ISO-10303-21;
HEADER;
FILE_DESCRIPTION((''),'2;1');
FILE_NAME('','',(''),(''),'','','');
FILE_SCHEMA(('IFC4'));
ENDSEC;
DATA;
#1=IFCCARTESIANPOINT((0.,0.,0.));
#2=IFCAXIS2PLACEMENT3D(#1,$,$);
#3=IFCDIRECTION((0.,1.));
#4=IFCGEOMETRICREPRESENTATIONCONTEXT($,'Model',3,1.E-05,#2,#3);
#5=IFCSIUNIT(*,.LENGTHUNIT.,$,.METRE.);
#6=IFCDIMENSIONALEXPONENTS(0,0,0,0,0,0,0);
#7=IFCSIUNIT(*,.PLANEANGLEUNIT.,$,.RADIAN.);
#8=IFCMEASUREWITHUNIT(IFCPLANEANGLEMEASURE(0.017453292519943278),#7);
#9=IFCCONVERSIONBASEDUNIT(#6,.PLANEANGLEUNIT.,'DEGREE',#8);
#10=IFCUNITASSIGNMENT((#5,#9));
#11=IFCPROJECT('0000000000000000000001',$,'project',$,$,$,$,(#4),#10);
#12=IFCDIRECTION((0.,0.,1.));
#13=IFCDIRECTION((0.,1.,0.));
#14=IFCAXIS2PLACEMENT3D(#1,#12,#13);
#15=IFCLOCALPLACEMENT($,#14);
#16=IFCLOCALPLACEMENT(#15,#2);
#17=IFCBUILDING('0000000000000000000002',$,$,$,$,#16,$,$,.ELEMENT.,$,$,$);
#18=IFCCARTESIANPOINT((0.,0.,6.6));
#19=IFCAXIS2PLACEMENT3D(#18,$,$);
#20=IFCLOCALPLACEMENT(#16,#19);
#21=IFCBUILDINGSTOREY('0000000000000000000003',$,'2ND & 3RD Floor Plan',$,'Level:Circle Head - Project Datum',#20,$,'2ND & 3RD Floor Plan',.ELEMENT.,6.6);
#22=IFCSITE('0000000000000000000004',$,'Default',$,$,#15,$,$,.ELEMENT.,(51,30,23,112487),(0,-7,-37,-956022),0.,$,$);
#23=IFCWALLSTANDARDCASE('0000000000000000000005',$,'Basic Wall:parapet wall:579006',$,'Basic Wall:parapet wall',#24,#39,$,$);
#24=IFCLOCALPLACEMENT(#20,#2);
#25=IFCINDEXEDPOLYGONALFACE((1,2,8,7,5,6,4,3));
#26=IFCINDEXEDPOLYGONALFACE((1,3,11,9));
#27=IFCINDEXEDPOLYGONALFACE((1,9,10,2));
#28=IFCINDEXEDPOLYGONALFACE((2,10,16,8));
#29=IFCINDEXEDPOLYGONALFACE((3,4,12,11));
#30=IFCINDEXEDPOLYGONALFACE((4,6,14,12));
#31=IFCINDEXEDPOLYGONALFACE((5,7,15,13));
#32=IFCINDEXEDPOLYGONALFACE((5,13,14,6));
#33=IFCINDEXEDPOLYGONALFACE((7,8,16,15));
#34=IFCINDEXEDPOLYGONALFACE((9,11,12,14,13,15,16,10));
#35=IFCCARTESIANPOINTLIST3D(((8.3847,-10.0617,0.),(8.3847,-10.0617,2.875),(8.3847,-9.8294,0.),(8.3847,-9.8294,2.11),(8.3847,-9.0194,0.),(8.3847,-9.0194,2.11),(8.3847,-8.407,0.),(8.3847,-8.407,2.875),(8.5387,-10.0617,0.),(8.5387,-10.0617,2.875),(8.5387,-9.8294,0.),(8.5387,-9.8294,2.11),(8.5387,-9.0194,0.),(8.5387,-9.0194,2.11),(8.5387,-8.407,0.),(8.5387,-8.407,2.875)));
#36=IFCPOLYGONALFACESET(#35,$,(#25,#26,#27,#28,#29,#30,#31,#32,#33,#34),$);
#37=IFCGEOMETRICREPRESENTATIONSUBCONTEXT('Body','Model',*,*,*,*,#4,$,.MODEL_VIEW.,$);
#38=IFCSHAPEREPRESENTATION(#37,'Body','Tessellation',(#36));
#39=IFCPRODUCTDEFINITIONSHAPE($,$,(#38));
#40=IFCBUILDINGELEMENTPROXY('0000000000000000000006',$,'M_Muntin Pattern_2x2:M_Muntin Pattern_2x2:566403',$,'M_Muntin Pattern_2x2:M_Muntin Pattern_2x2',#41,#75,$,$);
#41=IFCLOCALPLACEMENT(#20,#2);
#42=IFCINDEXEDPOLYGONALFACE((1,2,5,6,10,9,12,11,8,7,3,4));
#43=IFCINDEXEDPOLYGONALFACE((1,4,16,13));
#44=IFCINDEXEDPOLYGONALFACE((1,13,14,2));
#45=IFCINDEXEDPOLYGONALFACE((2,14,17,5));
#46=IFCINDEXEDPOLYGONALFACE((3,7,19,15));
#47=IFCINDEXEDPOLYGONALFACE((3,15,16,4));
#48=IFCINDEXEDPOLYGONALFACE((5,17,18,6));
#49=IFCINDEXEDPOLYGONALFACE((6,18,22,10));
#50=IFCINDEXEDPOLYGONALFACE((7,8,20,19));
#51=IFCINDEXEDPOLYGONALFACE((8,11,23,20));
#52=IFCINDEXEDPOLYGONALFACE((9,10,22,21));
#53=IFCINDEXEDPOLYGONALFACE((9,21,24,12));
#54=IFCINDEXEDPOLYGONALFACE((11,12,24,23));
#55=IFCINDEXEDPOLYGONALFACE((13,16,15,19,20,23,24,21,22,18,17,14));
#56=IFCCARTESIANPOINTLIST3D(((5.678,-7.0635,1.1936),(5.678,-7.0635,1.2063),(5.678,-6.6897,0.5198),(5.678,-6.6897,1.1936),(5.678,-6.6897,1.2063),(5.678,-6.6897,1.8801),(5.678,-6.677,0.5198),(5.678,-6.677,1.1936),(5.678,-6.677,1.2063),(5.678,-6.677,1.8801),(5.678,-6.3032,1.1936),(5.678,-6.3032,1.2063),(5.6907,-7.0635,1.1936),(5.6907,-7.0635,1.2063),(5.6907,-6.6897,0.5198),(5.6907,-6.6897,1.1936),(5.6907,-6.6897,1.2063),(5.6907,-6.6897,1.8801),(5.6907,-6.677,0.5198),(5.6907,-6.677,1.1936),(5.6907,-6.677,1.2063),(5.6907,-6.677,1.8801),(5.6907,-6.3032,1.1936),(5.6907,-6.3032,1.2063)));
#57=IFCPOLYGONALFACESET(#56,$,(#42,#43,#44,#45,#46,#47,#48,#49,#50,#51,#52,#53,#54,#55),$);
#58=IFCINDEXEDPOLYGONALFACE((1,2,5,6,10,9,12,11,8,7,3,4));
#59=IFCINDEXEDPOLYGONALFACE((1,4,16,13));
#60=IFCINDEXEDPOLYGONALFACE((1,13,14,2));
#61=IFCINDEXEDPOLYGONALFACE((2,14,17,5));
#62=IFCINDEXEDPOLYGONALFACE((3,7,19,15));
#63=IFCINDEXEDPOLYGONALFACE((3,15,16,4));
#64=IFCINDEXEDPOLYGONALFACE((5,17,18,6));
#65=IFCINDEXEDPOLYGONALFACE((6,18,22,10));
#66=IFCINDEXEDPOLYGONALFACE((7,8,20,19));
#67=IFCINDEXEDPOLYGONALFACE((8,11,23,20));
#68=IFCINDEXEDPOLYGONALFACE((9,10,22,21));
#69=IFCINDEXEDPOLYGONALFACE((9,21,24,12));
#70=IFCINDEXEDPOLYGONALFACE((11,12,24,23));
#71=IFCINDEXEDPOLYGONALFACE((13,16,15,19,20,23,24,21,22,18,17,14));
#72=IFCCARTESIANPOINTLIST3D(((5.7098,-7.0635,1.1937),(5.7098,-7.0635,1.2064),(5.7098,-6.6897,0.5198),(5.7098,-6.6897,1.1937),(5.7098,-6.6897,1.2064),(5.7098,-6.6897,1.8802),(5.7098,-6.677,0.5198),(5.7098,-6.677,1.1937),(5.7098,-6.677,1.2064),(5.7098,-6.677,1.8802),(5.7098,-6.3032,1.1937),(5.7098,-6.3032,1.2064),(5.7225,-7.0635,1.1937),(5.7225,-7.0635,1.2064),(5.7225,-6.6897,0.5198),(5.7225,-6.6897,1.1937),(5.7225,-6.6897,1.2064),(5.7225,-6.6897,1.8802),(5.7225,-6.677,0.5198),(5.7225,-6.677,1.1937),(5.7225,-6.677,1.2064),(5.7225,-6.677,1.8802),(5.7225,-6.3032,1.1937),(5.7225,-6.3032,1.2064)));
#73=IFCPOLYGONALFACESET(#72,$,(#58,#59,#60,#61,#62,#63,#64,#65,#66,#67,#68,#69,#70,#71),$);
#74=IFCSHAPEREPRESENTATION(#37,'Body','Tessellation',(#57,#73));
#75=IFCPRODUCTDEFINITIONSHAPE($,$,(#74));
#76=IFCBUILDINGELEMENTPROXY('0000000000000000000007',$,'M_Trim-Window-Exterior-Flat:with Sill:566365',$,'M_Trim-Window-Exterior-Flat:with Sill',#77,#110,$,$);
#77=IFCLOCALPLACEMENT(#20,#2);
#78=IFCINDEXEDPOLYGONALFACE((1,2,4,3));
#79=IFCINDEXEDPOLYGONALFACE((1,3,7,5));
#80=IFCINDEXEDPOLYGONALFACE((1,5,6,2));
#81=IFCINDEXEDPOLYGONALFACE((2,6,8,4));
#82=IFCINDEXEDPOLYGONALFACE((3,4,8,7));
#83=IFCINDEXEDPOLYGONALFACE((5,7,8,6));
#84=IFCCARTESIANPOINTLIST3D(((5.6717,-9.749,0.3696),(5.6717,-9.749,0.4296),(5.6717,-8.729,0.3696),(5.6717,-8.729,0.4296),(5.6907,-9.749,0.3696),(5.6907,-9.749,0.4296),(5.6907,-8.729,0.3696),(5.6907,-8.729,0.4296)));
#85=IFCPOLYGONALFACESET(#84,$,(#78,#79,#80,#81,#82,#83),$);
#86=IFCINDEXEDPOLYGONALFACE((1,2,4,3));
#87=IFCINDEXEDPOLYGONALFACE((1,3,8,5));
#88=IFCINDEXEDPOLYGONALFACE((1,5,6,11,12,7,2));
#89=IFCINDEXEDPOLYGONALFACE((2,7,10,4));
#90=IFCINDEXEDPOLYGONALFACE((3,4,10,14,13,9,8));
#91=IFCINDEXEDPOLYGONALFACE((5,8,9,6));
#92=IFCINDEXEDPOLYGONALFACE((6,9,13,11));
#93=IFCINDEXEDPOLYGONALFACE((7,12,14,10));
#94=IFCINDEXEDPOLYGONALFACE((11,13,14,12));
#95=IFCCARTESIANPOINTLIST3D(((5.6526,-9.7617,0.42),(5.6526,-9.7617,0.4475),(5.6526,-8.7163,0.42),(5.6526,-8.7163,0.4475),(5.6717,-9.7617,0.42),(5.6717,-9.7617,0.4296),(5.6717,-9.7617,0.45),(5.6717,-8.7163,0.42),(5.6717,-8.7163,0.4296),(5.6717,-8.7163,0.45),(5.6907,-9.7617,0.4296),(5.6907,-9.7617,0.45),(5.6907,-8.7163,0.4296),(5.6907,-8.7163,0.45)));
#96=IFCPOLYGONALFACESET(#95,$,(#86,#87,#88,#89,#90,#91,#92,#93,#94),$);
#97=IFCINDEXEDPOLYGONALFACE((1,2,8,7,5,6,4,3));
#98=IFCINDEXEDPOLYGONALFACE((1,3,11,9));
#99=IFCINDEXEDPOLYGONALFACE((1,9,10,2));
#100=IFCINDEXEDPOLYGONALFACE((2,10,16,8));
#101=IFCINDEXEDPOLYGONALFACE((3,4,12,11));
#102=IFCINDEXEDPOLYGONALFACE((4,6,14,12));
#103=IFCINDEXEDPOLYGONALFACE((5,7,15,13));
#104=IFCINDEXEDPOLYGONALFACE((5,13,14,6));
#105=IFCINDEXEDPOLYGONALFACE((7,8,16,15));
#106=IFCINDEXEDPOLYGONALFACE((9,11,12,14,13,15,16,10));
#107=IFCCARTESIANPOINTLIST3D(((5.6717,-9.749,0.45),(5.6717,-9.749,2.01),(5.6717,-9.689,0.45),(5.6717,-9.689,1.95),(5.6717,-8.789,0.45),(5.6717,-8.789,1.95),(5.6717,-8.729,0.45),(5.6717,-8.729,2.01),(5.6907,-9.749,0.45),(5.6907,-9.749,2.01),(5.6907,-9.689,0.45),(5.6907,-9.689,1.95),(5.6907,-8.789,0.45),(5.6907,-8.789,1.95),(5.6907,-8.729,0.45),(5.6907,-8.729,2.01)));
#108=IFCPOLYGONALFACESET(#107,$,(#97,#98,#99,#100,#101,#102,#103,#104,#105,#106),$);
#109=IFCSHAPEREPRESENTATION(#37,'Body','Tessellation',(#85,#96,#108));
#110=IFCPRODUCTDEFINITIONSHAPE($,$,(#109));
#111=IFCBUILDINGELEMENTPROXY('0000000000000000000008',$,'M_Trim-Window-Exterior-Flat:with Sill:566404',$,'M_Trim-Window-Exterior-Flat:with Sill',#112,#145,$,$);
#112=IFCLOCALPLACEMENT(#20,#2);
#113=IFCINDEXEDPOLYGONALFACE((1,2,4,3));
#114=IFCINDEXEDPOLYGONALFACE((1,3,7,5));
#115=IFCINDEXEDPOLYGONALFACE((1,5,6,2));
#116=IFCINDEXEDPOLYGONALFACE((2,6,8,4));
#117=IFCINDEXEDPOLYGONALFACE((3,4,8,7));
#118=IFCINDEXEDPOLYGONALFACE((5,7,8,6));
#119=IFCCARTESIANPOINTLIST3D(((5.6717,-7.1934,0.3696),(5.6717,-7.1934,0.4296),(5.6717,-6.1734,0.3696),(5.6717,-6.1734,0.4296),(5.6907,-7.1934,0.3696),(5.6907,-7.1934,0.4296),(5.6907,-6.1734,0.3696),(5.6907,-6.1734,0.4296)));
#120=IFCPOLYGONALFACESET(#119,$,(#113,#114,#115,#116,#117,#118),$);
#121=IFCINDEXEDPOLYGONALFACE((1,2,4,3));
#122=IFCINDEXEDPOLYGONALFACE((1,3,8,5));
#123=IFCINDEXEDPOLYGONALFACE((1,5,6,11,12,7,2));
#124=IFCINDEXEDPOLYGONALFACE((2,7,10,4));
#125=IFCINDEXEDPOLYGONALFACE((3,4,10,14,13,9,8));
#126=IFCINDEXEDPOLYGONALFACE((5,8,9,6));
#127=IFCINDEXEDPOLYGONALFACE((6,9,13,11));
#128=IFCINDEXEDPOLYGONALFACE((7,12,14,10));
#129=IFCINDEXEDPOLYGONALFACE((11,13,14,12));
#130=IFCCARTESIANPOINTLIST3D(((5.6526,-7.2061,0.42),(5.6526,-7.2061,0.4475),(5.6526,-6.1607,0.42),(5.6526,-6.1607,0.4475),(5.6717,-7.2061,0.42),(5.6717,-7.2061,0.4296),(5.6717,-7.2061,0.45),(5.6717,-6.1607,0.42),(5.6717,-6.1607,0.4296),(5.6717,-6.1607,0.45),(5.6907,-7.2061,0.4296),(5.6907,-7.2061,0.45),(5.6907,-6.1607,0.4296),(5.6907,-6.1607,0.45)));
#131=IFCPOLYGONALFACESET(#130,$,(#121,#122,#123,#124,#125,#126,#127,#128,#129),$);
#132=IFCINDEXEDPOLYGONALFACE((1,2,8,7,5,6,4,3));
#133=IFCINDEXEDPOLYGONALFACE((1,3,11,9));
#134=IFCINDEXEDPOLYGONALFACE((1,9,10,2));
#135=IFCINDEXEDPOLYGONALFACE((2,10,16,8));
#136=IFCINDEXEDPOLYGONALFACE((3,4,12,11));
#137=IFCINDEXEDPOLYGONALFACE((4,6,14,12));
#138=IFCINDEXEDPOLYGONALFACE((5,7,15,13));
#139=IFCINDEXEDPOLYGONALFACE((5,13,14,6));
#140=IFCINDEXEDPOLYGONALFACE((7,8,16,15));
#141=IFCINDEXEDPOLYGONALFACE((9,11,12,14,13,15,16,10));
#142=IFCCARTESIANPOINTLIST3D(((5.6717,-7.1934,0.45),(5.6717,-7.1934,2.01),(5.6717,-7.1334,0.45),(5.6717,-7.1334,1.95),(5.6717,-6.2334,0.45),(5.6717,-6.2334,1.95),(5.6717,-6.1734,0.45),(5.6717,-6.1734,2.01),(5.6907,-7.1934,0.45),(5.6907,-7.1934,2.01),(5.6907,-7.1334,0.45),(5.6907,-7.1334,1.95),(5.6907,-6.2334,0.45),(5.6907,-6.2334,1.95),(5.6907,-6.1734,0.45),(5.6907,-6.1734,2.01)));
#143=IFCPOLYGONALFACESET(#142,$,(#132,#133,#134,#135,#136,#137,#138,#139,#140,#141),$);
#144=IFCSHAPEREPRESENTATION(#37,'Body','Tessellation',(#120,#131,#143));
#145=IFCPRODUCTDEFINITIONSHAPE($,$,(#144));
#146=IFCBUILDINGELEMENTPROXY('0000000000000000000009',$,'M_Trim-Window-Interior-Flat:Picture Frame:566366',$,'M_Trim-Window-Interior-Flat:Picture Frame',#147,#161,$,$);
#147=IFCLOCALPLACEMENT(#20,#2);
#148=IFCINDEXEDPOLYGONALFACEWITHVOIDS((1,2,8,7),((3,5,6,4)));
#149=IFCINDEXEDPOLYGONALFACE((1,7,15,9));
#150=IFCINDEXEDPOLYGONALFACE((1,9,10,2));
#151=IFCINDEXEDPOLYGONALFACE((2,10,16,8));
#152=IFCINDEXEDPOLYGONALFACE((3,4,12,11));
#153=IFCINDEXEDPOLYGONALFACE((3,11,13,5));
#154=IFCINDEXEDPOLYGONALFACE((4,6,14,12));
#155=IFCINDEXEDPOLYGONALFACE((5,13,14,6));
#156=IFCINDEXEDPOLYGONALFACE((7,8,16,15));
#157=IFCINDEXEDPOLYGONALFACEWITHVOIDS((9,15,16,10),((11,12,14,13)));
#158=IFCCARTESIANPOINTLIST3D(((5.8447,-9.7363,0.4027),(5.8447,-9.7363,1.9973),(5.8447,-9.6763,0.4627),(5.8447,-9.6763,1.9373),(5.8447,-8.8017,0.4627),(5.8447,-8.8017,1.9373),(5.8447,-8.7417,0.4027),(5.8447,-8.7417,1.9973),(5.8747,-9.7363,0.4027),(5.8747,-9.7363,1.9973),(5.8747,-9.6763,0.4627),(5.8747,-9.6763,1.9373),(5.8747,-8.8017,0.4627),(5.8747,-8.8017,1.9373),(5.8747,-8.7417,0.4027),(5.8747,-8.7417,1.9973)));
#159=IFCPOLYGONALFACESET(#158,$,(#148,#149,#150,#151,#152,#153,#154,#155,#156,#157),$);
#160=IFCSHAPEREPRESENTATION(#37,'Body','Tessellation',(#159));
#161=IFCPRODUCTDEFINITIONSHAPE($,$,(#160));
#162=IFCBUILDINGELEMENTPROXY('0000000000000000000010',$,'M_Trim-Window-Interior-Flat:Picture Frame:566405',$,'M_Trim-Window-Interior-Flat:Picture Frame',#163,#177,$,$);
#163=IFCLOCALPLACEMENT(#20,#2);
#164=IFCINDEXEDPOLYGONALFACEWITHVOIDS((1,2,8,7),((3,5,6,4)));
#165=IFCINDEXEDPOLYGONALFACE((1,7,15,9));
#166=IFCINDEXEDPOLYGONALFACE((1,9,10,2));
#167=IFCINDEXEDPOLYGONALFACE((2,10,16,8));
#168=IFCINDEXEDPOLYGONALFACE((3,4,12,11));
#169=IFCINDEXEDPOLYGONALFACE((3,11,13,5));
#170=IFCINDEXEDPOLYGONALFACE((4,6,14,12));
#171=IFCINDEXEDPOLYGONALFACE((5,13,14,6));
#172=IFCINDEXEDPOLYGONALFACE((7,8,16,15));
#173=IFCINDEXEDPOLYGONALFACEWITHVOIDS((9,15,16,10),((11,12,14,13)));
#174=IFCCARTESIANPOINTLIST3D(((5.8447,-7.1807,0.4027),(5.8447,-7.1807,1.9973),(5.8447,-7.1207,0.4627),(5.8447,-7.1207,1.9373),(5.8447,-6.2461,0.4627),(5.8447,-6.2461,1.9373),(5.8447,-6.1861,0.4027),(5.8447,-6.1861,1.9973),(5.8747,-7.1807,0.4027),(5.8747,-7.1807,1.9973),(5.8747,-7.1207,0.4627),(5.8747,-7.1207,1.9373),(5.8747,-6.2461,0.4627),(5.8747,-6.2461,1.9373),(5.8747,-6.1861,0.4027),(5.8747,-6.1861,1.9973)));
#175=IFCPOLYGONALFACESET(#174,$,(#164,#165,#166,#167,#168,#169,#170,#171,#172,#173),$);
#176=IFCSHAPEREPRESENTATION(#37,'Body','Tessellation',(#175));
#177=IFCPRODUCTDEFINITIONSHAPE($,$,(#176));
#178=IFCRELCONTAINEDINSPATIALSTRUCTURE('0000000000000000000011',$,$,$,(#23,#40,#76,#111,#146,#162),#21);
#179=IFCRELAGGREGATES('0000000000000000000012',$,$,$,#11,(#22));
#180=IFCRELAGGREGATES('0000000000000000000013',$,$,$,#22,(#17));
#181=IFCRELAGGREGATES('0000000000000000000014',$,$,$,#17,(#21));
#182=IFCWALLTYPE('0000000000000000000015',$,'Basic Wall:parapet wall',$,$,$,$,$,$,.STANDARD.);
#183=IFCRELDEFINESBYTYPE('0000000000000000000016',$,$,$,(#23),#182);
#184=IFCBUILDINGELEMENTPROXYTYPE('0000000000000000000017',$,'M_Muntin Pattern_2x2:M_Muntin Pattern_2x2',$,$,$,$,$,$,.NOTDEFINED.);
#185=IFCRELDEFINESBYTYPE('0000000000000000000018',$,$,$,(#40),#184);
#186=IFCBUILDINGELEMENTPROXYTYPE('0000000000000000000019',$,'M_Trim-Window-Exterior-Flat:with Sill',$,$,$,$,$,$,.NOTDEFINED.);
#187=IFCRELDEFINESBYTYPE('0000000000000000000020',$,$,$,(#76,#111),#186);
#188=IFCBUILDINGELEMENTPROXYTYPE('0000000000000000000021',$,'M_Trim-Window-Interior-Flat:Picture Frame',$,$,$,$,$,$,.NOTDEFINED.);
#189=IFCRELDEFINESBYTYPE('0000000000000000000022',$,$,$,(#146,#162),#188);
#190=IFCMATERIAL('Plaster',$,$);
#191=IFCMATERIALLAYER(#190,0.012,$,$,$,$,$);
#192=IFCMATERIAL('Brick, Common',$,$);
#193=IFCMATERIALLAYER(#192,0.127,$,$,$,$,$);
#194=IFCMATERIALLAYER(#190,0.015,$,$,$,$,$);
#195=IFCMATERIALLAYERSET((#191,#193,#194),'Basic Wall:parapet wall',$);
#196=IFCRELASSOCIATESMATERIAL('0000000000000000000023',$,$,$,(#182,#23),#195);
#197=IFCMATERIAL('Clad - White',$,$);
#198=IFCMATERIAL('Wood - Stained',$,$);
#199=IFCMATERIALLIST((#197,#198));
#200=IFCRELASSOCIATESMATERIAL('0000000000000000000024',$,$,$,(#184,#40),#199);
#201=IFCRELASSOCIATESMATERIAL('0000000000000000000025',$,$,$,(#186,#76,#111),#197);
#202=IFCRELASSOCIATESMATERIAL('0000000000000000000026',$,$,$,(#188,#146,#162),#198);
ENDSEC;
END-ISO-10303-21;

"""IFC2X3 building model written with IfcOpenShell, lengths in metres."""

from ifc_helpers import new_model, entity, si_unit, converted_unit, direction, frame, frame_2d, origin, place, context, subcontext, project, spatial, polyline, rectangle, outline, extrude, clip, bounded_halfspace, source, transform, mapped, material, material_list, layer, layer_set, layer_usage, type_object, type_shapes, element, save


model = new_model("IFC2X3")

# Units and contexts
model_context = context("Model", 3, precision=1e-05, world=origin(), true_north=direction((0.0, 1.0)))
body_context = subcontext(model_context, "Body", "Model", "MODEL_VIEW")
ifc_project = project(units=[si_unit("LENGTHUNIT", "METRE"), converted_unit("PLANEANGLEUNIT", "DEGREE", entity("IfcPlaneAngleMeasure", 0.017453292519943278), si_unit("PLANEANGLEUNIT", "RADIAN"), dimensions=[0, 0, 0, 0, 0, 0, 0])], contexts=[model_context])

# Site, building, storey
site_placement = place(None, frame((0.0, 0.0, 0.0), z_axis=(0.0, 0.0, 1.0), x_axis=(0.0, 1.0, 0.0)))
site = spatial("IfcSite", under=ifc_project, at=site_placement, Name="Default", CompositionType="ELEMENT", RefLatitude=(51, 30, 23, 112487), RefLongitude=(0, -7, -37, -956022), RefElevation=0.0)
building_placement = place(site_placement, origin())
building = spatial("IfcBuilding", under=site, at=building_placement, CompositionType="ELEMENT")
storey_placement = place(building_placement, frame((0.0, 0.0, 6.6)))
storey = spatial("IfcBuildingStorey", under=building, at=storey_placement, Name="2ND & 3RD Floor Plan", ObjectType="Level:Circle Head - Project Datum", LongName="2ND & 3RD Floor Plan", CompositionType="ELEMENT", Elevation=6.6)

# Shared definitions
ifc_material_1 = material(Name="Plaster")
ifc_material_2 = material(Name="Brick, Common")

# Shared definitions
ifc_layer_1 = layer(ifc_material_1, 0.012)
ifc_layer_2 = layer(ifc_material_2, 0.127)
ifc_layer_3 = layer(ifc_material_1, 0.015)
ifc_layer_set_1 = layer_set([ifc_layer_1, ifc_layer_2, ifc_layer_3], Name="Basic Wall:parapet wall")
wall_type_1 = type_object("IfcWallType", Name="Basic Wall:parapet wall", PredefinedType="STANDARD", material=ifc_layer_set_1)

# Wall, opening
ifc_layer_usage_1 = layer_usage(ifc_layer_set_1, "AXIS2", "NEGATIVE", 0.077)
wall_1_placement = place(storey_placement, frame((8.4617, -8.407, 0.0), z_axis=(0.0, 0.0, 1.0), x_axis=(0.0, -1.0, 0.0)))
wall_1 = element("IfcWallStandardCase", 1, at=wall_1_placement, inside=storey, type_object=wall_type_1, material=ifc_layer_usage_1, Name="Basic Wall:parapet wall:579006", ObjectType="Basic Wall:parapet wall", context=body_context, shape_type="Clipping", body=[
    clip(extrude(rectangle(XDim=1.6547, YDim=0.154, at=frame_2d((0.8273, 0.0), x_axis=(-1.0, 0.0))), origin(), (0.0, 0.0, 1.0), 2.875), bounded_halfspace(frame((0.0, -0.077, 2.875), z_axis=(0.0, 0.0, -1.0), x_axis=(1.0, 0.0, 0.0)), True, frame((0.0, -0.077, 2.875)), polyline([(0.0, 0.0), (1.6547, 0.0), (1.6547, 0.154), (0.0, 0.154), (0.0, 0.0)]))),
])
opening_1_placement = place(wall_1_placement, frame((0.6123, -0.077, 0.0)))
element("IfcOpeningElement", 2, at=opening_1_placement, cuts=wall_1, ObjectType="Opening", context=body_context, shape_type="SweptSolid", body=[
    extrude(rectangle(XDim=2.11, YDim=0.81, at=frame_2d((1.055, 0.405), x_axis=(1.0, 0.0))), frame((0.0, 0.0, 0.0), z_axis=(0.0, 1.0, 0.0), x_axis=(0.0, 0.0, 1.0)), (0.0, 0.0, 1.0), 0.154),
])

# Building element proxies
ifc_material_3 = material(Name="Clad - White")
ifc_material_4 = material(Name="Wood - Stained")
ifc_material_list = material_list([ifc_material_3, ifc_material_4])
building_element_proxy_type_1 = type_object("IfcBuildingElementProxyType", Name="M_Muntin Pattern_2x2:M_Muntin Pattern_2x2", PredefinedType="NOTDEFINED", material=ifc_material_list)
shared_shape_1 = source(origin(), body_context, "Body", "SweptSolid", [
    extrude(outline(polyline([(0.0064, -0.0064), (0.6801, -0.0064), (0.6801, 0.0063), (0.0064, 0.0063), (0.0064, 0.3802), (-0.0063, 0.3802), (-0.0063, 0.0063), (-0.6802, 0.0063), (-0.6802, -0.0064), (-0.0063, -0.0064), (-0.0063, -0.3801), (0.0064, -0.3801), (0.0064, -0.0064)])), frame((0.0, 0.0095, 0.6801), z_axis=(0.0, 1.0, 0.0), x_axis=(0.0, 0.0, 1.0)), (0.0, 0.0, 1.0), 0.0127),
    extrude(outline(polyline([(0.0064, -0.0064), (0.6802, -0.0064), (0.6802, 0.0063), (0.0064, 0.0063), (0.0064, 0.3802), (-0.0063, 0.3802), (-0.0063, 0.0063), (-0.6802, 0.0063), (-0.6802, -0.0064), (-0.0063, -0.0064), (-0.0063, -0.3801), (0.0064, -0.3801), (0.0064, -0.0064)])), frame((0.0, -0.0222, 0.6802), z_axis=(0.0, 1.0, 0.0), x_axis=(0.0, 0.0, 1.0)), (0.0, 0.0, 1.0), 0.0127),
])
type_shapes(building_element_proxy_type_1, [shared_shape_1])
proxy_placement = place(storey_placement, frame((5.7002, -6.6834, 0.5198), z_axis=(0.0, 0.0, 1.0), x_axis=(0.0, 1.0, 0.0)))
element("IfcBuildingElementProxy", 3, at=proxy_placement, inside=storey, type_object=building_element_proxy_type_1, material=ifc_material_list, Name="M_Muntin Pattern_2x2:M_Muntin Pattern_2x2:566403", ObjectType="M_Muntin Pattern_2x2:M_Muntin Pattern_2x2", context=body_context, shape_type="MappedRepresentation", body=[
    mapped(shared_shape_1, transform((0.0, 0.0, 0.0), scale=1.0)),
])
building_element_proxy_type_2 = type_object("IfcBuildingElementProxyType", Name="M_Trim-Window-Exterior-Flat:with Sill", PredefinedType="NOTDEFINED", material=ifc_material_3)
shared_shape_2 = source(origin(), body_context, "Body", "SweptSolid", [
    extrude(rectangle(XDim=1.02, YDim=0.06, at=frame_2d((0.0, 0.0), x_axis=(1.0, 0.0))), frame((0.0, -1.5504, 0.0), z_axis=(0.0, 0.0, 1.0), x_axis=(-1.0, 0.0, 0.0)), (0.0, 0.0, 1.0), 0.019),
    extrude(outline(polyline([(-0.019, -0.0152), (0.0, -0.0152), (0.0, -0.0057), (0.019, -0.0057), (0.019, 0.0148), (0.0, 0.0148), (-0.019, 0.0123), (-0.019, -0.0152)])), frame((-0.5227, -1.5148, 0.019), z_axis=(1.0, 0.0, 0.0), x_axis=(0.0, 0.0, -1.0)), (0.0, 0.0, 1.0), 1.0454),
    extrude(outline(polyline([(-0.795, -0.51), (0.765, -0.51), (0.765, -0.45), (-0.735, -0.45), (-0.735, 0.45), (0.765, 0.45), (0.765, 0.51), (-0.795, 0.51), (-0.795, -0.51)])), frame((0.0, -0.735, 0.0), z_axis=(0.0, 0.0, 1.0), x_axis=(0.0, -1.0, 0.0)), (0.0, 0.0, 1.0), 0.019),
])
type_shapes(building_element_proxy_type_2, [shared_shape_2])
for number, where, z_axis, x_axis, name in (
    (4, (5.6907, -9.239, 1.95), (-1.0, 0.0, 0.0), (0.0, -1.0, 0.0), "M_Trim-Window-Exterior-Flat:with Sill:566365"),
    (5, (5.6907, -6.6834, 1.95), (-1.0, 0.0, 0.0), (0.0, -1.0, 0.0), "M_Trim-Window-Exterior-Flat:with Sill:566404"),
):
    element("IfcBuildingElementProxy", number, at=place(storey_placement, frame(where, z_axis=z_axis, x_axis=x_axis)), inside=storey, type_object=building_element_proxy_type_2, material=ifc_material_3, Name=name, ObjectType="M_Trim-Window-Exterior-Flat:with Sill", context=body_context, shape_type="MappedRepresentation", body=[
        mapped(shared_shape_2, transform((0.0, 0.0, 0.0), scale=1.0)),
    ])
building_element_proxy_type_3 = type_object("IfcBuildingElementProxyType", Name="M_Trim-Window-Interior-Flat:Picture Frame", PredefinedType="NOTDEFINED", material=ifc_material_4)
shared_shape_3 = source(origin(), body_context, "Body", "SweptSolid", [
    extrude(outline(polyline([(-0.4973, -0.7973), (0.4973, -0.7973), (0.4973, 0.7973), (-0.4973, 0.7973), (-0.4973, -0.7973)]), holes=[polyline([(-0.4373, -0.7373), (-0.4373, 0.7373), (0.4373, 0.7373), (0.4373, -0.7373), (-0.4373, -0.7373)])]), frame((0.0, -0.75, 0.0), z_axis=(0.0, 0.0, 1.0), x_axis=(-1.0, 0.0, 0.0)), (0.0, 0.0, 1.0), 0.03),
])
type_shapes(building_element_proxy_type_3, [shared_shape_3])
for number, where, z_axis, x_axis, name in (
    (6, (5.8447, -9.239, 1.95), (1.0, 0.0, 0.0), (0.0, 1.0, 0.0), "M_Trim-Window-Interior-Flat:Picture Frame:566366"),
    (7, (5.8447, -6.6834, 1.95), (1.0, 0.0, 0.0), (0.0, 1.0, 0.0), "M_Trim-Window-Interior-Flat:Picture Frame:566405"),
):
    element("IfcBuildingElementProxy", number, at=place(storey_placement, frame(where, z_axis=z_axis, x_axis=x_axis)), inside=storey, type_object=building_element_proxy_type_3, material=ifc_material_4, Name=name, ObjectType="M_Trim-Window-Interior-Flat:Picture Frame", context=body_context, shape_type="MappedRepresentation", body=[
        mapped(shared_shape_3, transform((0.0, 0.0, 0.0), scale=1.0)),
    ])

save(model, "model.ifc")
